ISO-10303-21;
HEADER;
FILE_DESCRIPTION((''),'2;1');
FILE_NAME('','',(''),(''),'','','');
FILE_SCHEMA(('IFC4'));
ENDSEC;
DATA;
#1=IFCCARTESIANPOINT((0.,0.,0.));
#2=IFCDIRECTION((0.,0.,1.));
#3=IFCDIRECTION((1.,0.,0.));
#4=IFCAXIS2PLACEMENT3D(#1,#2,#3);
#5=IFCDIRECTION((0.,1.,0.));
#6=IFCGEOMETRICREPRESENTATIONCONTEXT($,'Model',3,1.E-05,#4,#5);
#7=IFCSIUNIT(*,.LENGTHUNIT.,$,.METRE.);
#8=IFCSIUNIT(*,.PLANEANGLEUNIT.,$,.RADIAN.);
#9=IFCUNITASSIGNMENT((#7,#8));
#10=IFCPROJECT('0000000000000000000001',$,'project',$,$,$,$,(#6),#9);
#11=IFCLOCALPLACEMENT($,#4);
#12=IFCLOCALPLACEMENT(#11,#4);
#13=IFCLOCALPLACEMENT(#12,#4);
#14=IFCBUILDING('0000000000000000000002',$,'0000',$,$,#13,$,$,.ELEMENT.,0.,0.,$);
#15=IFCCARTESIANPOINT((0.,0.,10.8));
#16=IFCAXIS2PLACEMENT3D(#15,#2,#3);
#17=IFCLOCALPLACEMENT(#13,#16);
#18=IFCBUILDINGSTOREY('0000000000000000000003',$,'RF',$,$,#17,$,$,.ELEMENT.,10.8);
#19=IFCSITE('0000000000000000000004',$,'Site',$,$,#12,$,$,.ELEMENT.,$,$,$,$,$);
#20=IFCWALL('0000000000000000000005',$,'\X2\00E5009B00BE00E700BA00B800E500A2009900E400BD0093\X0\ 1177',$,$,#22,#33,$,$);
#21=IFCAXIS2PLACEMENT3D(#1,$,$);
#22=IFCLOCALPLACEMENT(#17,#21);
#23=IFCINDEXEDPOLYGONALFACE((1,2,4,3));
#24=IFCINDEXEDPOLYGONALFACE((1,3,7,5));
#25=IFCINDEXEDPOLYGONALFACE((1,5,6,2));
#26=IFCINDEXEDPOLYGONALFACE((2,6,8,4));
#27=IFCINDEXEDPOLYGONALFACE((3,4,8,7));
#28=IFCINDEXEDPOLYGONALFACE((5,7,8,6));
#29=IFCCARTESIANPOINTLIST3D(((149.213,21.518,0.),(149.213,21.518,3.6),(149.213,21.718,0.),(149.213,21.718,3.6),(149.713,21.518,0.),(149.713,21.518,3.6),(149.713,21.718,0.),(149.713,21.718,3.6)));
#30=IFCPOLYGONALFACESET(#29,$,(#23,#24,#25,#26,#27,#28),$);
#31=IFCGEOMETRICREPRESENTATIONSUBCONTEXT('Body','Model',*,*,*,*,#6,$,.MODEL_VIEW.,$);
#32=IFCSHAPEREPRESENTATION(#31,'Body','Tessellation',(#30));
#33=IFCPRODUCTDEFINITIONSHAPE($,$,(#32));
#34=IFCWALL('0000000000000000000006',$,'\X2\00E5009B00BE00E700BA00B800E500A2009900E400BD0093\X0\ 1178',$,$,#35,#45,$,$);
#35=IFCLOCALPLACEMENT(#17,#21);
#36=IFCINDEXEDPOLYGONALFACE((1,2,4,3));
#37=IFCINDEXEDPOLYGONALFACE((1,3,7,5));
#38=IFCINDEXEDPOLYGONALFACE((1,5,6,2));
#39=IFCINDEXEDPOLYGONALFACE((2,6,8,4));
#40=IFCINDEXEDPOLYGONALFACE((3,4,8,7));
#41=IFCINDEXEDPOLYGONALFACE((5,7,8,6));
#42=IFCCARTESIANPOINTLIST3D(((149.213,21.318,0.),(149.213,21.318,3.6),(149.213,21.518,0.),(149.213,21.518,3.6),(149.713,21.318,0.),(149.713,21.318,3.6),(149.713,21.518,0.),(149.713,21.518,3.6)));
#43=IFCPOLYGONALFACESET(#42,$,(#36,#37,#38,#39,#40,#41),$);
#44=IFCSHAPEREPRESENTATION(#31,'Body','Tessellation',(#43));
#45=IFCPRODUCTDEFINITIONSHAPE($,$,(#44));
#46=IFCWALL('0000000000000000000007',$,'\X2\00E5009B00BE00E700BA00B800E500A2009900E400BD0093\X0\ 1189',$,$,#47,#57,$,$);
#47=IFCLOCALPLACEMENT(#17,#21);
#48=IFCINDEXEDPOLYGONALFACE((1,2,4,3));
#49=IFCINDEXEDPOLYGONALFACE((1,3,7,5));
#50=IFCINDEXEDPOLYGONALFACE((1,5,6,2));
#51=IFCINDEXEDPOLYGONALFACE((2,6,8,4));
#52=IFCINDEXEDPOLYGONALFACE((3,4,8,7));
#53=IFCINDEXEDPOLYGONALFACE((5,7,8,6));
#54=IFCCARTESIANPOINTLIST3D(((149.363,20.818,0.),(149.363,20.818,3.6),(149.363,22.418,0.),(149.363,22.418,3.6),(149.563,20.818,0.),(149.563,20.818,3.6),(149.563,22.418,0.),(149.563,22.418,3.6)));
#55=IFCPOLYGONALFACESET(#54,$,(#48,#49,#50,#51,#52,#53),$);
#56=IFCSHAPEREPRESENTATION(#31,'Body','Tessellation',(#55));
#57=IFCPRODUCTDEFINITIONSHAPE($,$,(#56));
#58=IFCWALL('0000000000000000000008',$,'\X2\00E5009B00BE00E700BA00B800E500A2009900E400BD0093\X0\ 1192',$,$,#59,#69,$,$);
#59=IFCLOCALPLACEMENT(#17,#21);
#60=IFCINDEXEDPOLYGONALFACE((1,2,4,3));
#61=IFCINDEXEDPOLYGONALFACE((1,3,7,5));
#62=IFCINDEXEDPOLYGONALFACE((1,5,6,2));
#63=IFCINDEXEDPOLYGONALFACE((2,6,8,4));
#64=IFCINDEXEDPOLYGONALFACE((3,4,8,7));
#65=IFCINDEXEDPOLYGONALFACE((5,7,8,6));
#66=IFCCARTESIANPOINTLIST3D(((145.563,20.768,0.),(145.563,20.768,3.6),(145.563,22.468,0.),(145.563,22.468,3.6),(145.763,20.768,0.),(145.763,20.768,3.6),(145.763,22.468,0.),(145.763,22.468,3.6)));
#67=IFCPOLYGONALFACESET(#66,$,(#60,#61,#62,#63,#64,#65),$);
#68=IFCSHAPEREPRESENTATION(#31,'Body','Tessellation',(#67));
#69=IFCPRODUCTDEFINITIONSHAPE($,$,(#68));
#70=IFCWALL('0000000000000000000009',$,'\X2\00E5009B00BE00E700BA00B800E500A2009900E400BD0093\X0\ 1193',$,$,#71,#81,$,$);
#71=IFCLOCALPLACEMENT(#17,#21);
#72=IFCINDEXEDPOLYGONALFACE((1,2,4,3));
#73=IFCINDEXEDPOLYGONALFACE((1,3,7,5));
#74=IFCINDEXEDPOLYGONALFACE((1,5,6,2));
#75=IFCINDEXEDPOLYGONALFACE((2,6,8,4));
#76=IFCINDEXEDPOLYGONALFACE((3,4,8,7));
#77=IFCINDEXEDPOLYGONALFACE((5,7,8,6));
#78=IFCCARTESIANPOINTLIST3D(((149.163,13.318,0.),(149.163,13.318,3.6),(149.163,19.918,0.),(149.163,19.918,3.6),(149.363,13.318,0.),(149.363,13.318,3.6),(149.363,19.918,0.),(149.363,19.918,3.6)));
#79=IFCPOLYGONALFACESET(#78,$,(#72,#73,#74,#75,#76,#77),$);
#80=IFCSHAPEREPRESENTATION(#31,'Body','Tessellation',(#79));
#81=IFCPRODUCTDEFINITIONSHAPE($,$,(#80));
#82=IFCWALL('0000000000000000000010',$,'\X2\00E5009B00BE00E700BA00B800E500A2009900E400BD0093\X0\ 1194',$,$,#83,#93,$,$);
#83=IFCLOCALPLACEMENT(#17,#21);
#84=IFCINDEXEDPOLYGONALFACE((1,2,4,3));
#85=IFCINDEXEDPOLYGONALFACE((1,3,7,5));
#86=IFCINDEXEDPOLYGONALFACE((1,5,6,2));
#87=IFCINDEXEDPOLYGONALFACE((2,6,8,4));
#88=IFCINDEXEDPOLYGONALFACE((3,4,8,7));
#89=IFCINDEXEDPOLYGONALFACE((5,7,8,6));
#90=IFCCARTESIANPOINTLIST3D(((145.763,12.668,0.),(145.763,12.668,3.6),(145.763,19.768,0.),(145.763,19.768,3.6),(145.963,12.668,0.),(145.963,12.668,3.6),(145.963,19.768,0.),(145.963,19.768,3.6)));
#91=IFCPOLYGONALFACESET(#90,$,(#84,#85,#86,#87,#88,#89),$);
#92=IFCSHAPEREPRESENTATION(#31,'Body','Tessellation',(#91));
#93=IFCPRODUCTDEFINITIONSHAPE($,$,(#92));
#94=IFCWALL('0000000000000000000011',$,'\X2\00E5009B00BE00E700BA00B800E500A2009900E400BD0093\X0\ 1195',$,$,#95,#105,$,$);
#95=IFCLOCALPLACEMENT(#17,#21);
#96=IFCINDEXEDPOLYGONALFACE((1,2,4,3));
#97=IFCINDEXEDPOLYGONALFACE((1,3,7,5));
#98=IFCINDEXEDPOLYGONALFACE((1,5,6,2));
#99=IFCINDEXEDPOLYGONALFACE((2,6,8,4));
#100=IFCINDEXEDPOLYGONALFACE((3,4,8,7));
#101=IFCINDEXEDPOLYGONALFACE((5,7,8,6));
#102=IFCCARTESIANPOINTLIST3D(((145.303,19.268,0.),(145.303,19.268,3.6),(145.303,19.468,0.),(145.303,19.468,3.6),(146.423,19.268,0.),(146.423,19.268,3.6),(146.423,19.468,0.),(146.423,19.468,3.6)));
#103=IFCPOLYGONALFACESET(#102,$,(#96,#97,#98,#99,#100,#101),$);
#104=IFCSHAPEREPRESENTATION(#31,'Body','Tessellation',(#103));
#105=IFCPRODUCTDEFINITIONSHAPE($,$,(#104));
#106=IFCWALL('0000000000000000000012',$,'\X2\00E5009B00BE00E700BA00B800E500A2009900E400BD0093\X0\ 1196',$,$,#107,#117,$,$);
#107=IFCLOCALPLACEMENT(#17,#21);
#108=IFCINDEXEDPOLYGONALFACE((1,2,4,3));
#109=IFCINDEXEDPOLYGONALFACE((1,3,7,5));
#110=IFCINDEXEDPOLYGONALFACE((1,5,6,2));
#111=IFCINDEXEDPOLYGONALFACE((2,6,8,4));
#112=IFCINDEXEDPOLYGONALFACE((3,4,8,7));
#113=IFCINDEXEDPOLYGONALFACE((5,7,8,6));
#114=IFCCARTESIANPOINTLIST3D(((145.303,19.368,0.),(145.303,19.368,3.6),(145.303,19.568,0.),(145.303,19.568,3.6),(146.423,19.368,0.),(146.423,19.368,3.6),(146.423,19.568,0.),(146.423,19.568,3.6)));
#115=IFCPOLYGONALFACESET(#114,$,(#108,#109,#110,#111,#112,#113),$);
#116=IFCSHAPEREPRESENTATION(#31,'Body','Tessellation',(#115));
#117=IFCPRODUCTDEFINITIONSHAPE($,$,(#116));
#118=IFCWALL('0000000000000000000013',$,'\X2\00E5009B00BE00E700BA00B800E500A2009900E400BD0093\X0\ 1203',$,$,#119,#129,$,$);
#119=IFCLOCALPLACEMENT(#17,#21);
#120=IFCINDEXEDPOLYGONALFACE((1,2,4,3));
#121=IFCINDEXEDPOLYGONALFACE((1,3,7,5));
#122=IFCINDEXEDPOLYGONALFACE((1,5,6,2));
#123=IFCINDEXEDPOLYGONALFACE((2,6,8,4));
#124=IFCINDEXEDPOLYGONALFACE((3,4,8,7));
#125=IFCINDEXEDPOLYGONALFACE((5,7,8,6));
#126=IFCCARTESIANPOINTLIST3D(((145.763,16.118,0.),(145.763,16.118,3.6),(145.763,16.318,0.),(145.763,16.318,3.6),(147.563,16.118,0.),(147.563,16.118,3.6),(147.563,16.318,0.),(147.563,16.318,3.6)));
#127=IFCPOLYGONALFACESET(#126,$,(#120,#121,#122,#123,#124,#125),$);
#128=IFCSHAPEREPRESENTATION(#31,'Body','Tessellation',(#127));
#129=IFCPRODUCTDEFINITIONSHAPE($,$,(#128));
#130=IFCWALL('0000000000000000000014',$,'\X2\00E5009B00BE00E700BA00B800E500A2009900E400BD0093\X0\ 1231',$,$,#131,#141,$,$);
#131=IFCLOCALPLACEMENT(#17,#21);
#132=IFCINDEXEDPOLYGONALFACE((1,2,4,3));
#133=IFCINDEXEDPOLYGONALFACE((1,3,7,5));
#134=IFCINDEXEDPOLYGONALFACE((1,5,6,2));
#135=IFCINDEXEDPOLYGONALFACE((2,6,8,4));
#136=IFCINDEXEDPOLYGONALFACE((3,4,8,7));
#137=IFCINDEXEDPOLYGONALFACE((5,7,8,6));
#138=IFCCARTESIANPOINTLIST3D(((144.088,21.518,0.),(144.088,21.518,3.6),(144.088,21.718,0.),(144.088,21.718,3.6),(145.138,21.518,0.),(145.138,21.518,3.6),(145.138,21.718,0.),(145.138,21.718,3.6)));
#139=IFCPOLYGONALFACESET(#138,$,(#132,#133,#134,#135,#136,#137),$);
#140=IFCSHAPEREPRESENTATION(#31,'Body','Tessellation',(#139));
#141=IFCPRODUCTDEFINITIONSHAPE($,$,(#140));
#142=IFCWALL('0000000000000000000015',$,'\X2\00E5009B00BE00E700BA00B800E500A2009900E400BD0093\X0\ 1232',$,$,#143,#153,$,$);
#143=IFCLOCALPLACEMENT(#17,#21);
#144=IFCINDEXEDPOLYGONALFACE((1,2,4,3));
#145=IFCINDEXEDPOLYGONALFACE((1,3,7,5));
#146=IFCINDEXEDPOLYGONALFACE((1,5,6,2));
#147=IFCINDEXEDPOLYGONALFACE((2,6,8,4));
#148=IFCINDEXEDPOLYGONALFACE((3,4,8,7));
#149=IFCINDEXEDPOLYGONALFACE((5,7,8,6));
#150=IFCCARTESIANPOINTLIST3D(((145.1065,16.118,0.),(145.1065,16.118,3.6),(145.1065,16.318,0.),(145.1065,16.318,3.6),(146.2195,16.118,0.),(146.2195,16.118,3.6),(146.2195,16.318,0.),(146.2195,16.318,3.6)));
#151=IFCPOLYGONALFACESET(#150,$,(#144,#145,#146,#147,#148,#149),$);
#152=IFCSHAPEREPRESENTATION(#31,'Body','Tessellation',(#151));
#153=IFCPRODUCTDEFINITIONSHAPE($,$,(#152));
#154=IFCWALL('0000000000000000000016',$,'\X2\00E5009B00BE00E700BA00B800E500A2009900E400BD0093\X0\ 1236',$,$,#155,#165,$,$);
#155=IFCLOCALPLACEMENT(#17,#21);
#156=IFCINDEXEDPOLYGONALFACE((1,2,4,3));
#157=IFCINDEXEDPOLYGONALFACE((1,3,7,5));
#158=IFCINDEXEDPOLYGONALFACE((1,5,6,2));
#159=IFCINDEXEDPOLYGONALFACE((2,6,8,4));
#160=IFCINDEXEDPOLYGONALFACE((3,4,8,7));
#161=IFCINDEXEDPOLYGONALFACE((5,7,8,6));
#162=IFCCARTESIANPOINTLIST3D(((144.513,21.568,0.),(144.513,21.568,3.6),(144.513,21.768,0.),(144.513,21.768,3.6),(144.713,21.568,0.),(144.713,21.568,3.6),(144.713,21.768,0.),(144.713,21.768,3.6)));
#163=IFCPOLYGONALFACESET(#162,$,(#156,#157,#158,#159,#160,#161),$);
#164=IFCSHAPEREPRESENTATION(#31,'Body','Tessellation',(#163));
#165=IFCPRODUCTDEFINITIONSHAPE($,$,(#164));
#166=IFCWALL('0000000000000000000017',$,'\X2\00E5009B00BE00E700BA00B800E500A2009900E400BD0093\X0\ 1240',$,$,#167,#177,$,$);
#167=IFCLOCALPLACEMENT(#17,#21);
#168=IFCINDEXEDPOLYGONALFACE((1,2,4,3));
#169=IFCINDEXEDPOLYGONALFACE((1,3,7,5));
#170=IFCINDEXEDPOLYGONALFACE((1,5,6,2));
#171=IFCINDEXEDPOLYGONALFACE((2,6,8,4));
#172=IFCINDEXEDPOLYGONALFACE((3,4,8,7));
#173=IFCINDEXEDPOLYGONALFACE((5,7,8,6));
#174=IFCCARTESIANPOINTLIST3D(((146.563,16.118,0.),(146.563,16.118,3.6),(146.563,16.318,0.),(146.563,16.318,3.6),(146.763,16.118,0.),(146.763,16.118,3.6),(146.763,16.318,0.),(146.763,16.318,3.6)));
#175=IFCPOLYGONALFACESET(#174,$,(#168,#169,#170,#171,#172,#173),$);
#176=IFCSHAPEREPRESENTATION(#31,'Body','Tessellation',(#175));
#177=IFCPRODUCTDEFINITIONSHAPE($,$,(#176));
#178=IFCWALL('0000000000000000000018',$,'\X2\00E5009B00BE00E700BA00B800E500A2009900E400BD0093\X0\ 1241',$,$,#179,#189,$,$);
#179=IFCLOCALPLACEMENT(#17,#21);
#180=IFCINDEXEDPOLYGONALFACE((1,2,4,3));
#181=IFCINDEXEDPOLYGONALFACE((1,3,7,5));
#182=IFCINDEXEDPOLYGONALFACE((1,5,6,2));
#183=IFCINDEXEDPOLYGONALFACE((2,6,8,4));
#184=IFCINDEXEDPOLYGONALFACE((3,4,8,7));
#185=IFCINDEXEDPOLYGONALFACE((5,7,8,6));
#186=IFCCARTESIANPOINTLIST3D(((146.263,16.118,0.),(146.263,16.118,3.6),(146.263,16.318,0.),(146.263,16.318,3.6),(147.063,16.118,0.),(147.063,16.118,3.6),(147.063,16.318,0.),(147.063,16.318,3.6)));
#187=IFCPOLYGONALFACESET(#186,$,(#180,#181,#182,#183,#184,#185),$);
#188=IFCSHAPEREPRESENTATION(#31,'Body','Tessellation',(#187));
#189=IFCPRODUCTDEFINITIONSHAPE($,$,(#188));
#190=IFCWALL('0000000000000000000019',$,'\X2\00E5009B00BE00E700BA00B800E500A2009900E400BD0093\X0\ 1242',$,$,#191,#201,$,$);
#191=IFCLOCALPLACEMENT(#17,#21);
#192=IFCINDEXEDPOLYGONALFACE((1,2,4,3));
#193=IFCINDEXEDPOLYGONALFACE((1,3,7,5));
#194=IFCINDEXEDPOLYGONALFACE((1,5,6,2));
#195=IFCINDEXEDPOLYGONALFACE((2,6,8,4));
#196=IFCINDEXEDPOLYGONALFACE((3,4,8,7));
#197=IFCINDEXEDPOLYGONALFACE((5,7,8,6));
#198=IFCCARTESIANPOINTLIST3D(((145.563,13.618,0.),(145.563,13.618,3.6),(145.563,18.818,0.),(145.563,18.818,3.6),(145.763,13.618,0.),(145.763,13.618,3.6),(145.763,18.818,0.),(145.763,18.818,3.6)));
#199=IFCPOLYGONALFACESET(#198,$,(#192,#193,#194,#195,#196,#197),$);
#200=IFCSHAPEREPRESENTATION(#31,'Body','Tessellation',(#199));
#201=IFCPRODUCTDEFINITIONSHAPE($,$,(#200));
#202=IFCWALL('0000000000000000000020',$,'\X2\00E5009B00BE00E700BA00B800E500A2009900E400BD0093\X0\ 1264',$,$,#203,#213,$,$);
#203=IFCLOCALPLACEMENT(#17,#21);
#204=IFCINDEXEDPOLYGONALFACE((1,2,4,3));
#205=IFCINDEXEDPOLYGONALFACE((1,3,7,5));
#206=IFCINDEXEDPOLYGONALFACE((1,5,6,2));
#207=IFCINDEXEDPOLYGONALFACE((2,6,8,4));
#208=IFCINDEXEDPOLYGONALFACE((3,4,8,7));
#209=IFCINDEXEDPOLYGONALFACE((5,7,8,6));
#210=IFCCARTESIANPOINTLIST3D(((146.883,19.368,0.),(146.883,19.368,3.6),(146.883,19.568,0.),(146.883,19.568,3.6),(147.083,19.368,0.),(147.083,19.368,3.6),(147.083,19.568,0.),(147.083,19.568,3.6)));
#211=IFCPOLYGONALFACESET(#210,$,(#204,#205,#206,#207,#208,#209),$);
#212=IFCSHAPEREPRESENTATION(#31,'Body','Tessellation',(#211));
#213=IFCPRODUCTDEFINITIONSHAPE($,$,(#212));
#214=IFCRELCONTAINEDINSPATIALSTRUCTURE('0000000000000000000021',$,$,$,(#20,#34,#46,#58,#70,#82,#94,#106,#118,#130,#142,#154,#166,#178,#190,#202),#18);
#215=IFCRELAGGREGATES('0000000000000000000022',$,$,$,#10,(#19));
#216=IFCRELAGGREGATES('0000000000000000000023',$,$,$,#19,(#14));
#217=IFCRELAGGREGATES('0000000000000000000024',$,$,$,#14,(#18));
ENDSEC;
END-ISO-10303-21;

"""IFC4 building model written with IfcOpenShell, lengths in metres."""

from ifc_helpers import new_model, si_unit, direction, frame, frame_2d, origin_with_axes, place, context, subcontext, project, spatial, rectangle, extrude, element, save


model = new_model("IFC4")

# Units and contexts
model_context = context("Model", 3, precision=1e-05, world=origin_with_axes(), true_north=direction((0.0, 1.0, 0.0)))
body_context = subcontext(model_context, "Body", "Model", "MODEL_VIEW")
ifc_project = project(units=[si_unit("LENGTHUNIT", "METRE"), si_unit("PLANEANGLEUNIT", "RADIAN")], contexts=[model_context])

# Site, building, storey
placement = place(None, origin_with_axes())
site_placement = place(placement, origin_with_axes())
site = spatial("IfcSite", under=ifc_project, at=site_placement, Name="Site", CompositionType="ELEMENT")
building_placement = place(site_placement, origin_with_axes())
building = spatial("IfcBuilding", under=site, at=building_placement, Name="0000", CompositionType="ELEMENT", ElevationOfRefHeight=0.0, ElevationOfTerrain=0.0)
storey_placement = place(building_placement, frame((0.0, 0.0, 10.8), z_axis=(0.0, 0.0, 1.0), x_axis=(1.0, 0.0, 0.0)))
storey = spatial("IfcBuildingStorey", under=building, at=storey_placement, Name="RF", CompositionType="ELEMENT", Elevation=10.8)

# Walls
for number, where, z_axis, x_axis, name in (
    (1, (149.463, 21.618, 0.0), (0.0, 0.0, 1.0), (1.0, 0.0, 0.0), "å\u009b¾çº¸å¢\u0099ä½\u0093 1177"),
    (2, (149.463, 21.418, 0.0), (0.0, 0.0, 1.0), (1.0, 0.0, 0.0), "å\u009b¾çº¸å¢\u0099ä½\u0093 1178"),
):
    element("IfcWall", number, at=place(storey_placement, frame(where, z_axis=z_axis, x_axis=x_axis)), inside=storey, Name=name, context=body_context, shape_type="SweptSolid", body=[
        extrude(rectangle(XDim=0.5, YDim=0.2, at=frame_2d((0.0, 0.0), x_axis=(1.0, 0.0, 0.0))), frame((0.0, 0.0, 0.0), z_axis=(0.0, 0.0, 1.0)), (0.0, 0.0, 1.0), 3.6),
    ])
wall_1_placement = place(storey_placement, frame((149.463, 21.618, 0.0), z_axis=(0.0, 0.0, 1.0), x_axis=(0.0, 1.0, 0.0)))
element("IfcWall", 3, at=wall_1_placement, inside=storey, Name="å\u009b¾çº¸å¢\u0099ä½\u0093 1189", context=body_context, shape_type="SweptSolid", body=[
    extrude(rectangle(XDim=1.6, YDim=0.2, at=frame_2d((0.0, 0.0), x_axis=(1.0, 0.0, 0.0))), frame((0.0, 0.0, 0.0), z_axis=(0.0, 0.0, 1.0)), (0.0, 0.0, 1.0), 3.6),
])
wall_2_placement = place(storey_placement, frame((145.663, 21.618, 0.0), z_axis=(0.0, 0.0, 1.0), x_axis=(0.0, 1.0, 0.0)))
element("IfcWall", 4, at=wall_2_placement, inside=storey, Name="å\u009b¾çº¸å¢\u0099ä½\u0093 1192", context=body_context, shape_type="SweptSolid", body=[
    extrude(rectangle(XDim=1.7, YDim=0.2, at=frame_2d((0.0, 0.0), x_axis=(1.0, 0.0, 0.0))), frame((0.0, 0.0, 0.0), z_axis=(0.0, 0.0, 1.0)), (0.0, 0.0, 1.0), 3.6),
])
wall_3_placement = place(storey_placement, frame((149.263, 16.618, 0.0), z_axis=(0.0, 0.0, 1.0), x_axis=(0.0, 1.0, 0.0)))
element("IfcWall", 5, at=wall_3_placement, inside=storey, Name="å\u009b¾çº¸å¢\u0099ä½\u0093 1193", context=body_context, shape_type="SweptSolid", body=[
    extrude(rectangle(XDim=6.6, YDim=0.2, at=frame_2d((0.0, 0.0), x_axis=(1.0, 0.0, 0.0))), frame((0.0, 0.0, 0.0), z_axis=(0.0, 0.0, 1.0)), (0.0, 0.0, 1.0), 3.6),
])
wall_4_placement = place(storey_placement, frame((145.863, 16.218, 0.0), z_axis=(0.0, 0.0, 1.0), x_axis=(0.0, 1.0, 0.0)))
element("IfcWall", 6, at=wall_4_placement, inside=storey, Name="å\u009b¾çº¸å¢\u0099ä½\u0093 1194", context=body_context, shape_type="SweptSolid", body=[
    extrude(rectangle(XDim=7.1, YDim=0.2, at=frame_2d((0.0, 0.0), x_axis=(1.0, 0.0, 0.0))), frame((0.0, 0.0, 0.0), z_axis=(0.0, 0.0, 1.0)), (0.0, 0.0, 1.0), 3.6),
])
for number, where, z_axis, x_axis, name in (
    (7, (145.863, 19.368, 0.0), (0.0, 0.0, 1.0), (1.0, 0.0, 0.0), "å\u009b¾çº¸å¢\u0099ä½\u0093 1195"),
    (8, (145.863, 19.468, 0.0), (0.0, 0.0, 1.0), (1.0, 0.0, 0.0), "å\u009b¾çº¸å¢\u0099ä½\u0093 1196"),
):
    element("IfcWall", number, at=place(storey_placement, frame(where, z_axis=z_axis, x_axis=x_axis)), inside=storey, Name=name, context=body_context, shape_type="SweptSolid", body=[
        extrude(rectangle(XDim=1.12, YDim=0.2, at=frame_2d((0.0, 0.0), x_axis=(1.0, 0.0, 0.0))), frame((0.0, 0.0, 0.0), z_axis=(0.0, 0.0, 1.0)), (0.0, 0.0, 1.0), 3.6),
    ])
wall_5_placement = place(storey_placement, frame((146.663, 16.218, 0.0), z_axis=(0.0, 0.0, 1.0), x_axis=(1.0, 0.0, 0.0)))
element("IfcWall", 9, at=wall_5_placement, inside=storey, Name="å\u009b¾çº¸å¢\u0099ä½\u0093 1203", context=body_context, shape_type="SweptSolid", body=[
    extrude(rectangle(XDim=1.8, YDim=0.2, at=frame_2d((0.0, 0.0), x_axis=(1.0, 0.0, 0.0))), frame((0.0, 0.0, 0.0), z_axis=(0.0, 0.0, 1.0)), (0.0, 0.0, 1.0), 3.6),
])
wall_6_placement = place(storey_placement, frame((144.613, 21.618, 0.0), z_axis=(0.0, 0.0, 1.0), x_axis=(1.0, 0.0, 0.0)))
element("IfcWall", 10, at=wall_6_placement, inside=storey, Name="å\u009b¾çº¸å¢\u0099ä½\u0093 1231", context=body_context, shape_type="SweptSolid", body=[
    extrude(rectangle(XDim=1.05, YDim=0.2, at=frame_2d((0.0, 0.0), x_axis=(1.0, 0.0, 0.0))), frame((0.0, 0.0, 0.0), z_axis=(0.0, 0.0, 1.0)), (0.0, 0.0, 1.0), 3.6),
])
wall_7_placement = place(storey_placement, frame((145.663, 16.218, 0.0), z_axis=(0.0, 0.0, 1.0), x_axis=(-1.0, 0.0, 0.0)))
element("IfcWall", 11, at=wall_7_placement, inside=storey, Name="å\u009b¾çº¸å¢\u0099ä½\u0093 1232", context=body_context, shape_type="SweptSolid", body=[
    extrude(rectangle(XDim=1.113, YDim=0.2, at=frame_2d((0.0, 0.0), x_axis=(1.0, 0.0, 0.0))), frame((0.0, 0.0, 0.0), z_axis=(0.0, 0.0, 1.0)), (0.0, 0.0, 1.0), 3.6),
])
for number, where, z_axis, x_axis, name in (
    (12, (144.613, 21.668, 0.0), (0.0, 0.0, 1.0), (-1.0, 0.0, 0.0), "å\u009b¾çº¸å¢\u0099ä½\u0093 1236"),
    (13, (146.663, 16.218, 0.0), (0.0, 0.0, 1.0), (0.0, -1.0, 0.0), "å\u009b¾çº¸å¢\u0099ä½\u0093 1240"),
):
    element("IfcWall", number, at=place(storey_placement, frame(where, z_axis=z_axis, x_axis=x_axis)), inside=storey, Name=name, context=body_context, shape_type="SweptSolid", body=[
        extrude(rectangle(XDim=0.2, YDim=0.2, at=frame_2d((0.0, 0.0), x_axis=(1.0, 0.0, 0.0))), frame((0.0, 0.0, 0.0), z_axis=(0.0, 0.0, 1.0)), (0.0, 0.0, 1.0), 3.6),
    ])
wall_8_placement = place(storey_placement, frame((146.663, 16.218, 0.0), z_axis=(0.0, 0.0, 1.0), x_axis=(-1.0, 0.0, 0.0)))
element("IfcWall", 14, at=wall_8_placement, inside=storey, Name="å\u009b¾çº¸å¢\u0099ä½\u0093 1241", context=body_context, shape_type="SweptSolid", body=[
    extrude(rectangle(XDim=0.8, YDim=0.2, at=frame_2d((0.0, 0.0), x_axis=(1.0, 0.0, 0.0))), frame((0.0, 0.0, 0.0), z_axis=(0.0, 0.0, 1.0)), (0.0, 0.0, 1.0), 3.6),
])
wall_9_placement = place(storey_placement, frame((145.663, 16.218, 0.0), z_axis=(0.0, 0.0, 1.0), x_axis=(0.0, 1.0, 0.0)))
element("IfcWall", 15, at=wall_9_placement, inside=storey, Name="å\u009b¾çº¸å¢\u0099ä½\u0093 1242", context=body_context, shape_type="SweptSolid", body=[
    extrude(rectangle(XDim=5.2, YDim=0.2, at=frame_2d((0.0, 0.0), x_axis=(1.0, 0.0, 0.0))), frame((0.0, 0.0, 0.0), z_axis=(0.0, 0.0, 1.0)), (0.0, 0.0, 1.0), 3.6),
])
for number, where, z_axis, x_axis, name in (
    (16, (146.983, 19.468, 0.0), (0.0, 0.0, 1.0), (0.0, -1.0, 0.0), "å\u009b¾çº¸å¢\u0099ä½\u0093 1264"),
):
    element("IfcWall", number, at=place(storey_placement, frame(where, z_axis=z_axis, x_axis=x_axis)), inside=storey, Name=name, context=body_context, shape_type="SweptSolid", body=[
        extrude(rectangle(XDim=0.2, YDim=0.2, at=frame_2d((0.0, 0.0), x_axis=(1.0, 0.0, 0.0))), frame((0.0, 0.0, 0.0), z_axis=(0.0, 0.0, 1.0)), (0.0, 0.0, 1.0), 3.6),
    ])

save(model, "model.ifc")
